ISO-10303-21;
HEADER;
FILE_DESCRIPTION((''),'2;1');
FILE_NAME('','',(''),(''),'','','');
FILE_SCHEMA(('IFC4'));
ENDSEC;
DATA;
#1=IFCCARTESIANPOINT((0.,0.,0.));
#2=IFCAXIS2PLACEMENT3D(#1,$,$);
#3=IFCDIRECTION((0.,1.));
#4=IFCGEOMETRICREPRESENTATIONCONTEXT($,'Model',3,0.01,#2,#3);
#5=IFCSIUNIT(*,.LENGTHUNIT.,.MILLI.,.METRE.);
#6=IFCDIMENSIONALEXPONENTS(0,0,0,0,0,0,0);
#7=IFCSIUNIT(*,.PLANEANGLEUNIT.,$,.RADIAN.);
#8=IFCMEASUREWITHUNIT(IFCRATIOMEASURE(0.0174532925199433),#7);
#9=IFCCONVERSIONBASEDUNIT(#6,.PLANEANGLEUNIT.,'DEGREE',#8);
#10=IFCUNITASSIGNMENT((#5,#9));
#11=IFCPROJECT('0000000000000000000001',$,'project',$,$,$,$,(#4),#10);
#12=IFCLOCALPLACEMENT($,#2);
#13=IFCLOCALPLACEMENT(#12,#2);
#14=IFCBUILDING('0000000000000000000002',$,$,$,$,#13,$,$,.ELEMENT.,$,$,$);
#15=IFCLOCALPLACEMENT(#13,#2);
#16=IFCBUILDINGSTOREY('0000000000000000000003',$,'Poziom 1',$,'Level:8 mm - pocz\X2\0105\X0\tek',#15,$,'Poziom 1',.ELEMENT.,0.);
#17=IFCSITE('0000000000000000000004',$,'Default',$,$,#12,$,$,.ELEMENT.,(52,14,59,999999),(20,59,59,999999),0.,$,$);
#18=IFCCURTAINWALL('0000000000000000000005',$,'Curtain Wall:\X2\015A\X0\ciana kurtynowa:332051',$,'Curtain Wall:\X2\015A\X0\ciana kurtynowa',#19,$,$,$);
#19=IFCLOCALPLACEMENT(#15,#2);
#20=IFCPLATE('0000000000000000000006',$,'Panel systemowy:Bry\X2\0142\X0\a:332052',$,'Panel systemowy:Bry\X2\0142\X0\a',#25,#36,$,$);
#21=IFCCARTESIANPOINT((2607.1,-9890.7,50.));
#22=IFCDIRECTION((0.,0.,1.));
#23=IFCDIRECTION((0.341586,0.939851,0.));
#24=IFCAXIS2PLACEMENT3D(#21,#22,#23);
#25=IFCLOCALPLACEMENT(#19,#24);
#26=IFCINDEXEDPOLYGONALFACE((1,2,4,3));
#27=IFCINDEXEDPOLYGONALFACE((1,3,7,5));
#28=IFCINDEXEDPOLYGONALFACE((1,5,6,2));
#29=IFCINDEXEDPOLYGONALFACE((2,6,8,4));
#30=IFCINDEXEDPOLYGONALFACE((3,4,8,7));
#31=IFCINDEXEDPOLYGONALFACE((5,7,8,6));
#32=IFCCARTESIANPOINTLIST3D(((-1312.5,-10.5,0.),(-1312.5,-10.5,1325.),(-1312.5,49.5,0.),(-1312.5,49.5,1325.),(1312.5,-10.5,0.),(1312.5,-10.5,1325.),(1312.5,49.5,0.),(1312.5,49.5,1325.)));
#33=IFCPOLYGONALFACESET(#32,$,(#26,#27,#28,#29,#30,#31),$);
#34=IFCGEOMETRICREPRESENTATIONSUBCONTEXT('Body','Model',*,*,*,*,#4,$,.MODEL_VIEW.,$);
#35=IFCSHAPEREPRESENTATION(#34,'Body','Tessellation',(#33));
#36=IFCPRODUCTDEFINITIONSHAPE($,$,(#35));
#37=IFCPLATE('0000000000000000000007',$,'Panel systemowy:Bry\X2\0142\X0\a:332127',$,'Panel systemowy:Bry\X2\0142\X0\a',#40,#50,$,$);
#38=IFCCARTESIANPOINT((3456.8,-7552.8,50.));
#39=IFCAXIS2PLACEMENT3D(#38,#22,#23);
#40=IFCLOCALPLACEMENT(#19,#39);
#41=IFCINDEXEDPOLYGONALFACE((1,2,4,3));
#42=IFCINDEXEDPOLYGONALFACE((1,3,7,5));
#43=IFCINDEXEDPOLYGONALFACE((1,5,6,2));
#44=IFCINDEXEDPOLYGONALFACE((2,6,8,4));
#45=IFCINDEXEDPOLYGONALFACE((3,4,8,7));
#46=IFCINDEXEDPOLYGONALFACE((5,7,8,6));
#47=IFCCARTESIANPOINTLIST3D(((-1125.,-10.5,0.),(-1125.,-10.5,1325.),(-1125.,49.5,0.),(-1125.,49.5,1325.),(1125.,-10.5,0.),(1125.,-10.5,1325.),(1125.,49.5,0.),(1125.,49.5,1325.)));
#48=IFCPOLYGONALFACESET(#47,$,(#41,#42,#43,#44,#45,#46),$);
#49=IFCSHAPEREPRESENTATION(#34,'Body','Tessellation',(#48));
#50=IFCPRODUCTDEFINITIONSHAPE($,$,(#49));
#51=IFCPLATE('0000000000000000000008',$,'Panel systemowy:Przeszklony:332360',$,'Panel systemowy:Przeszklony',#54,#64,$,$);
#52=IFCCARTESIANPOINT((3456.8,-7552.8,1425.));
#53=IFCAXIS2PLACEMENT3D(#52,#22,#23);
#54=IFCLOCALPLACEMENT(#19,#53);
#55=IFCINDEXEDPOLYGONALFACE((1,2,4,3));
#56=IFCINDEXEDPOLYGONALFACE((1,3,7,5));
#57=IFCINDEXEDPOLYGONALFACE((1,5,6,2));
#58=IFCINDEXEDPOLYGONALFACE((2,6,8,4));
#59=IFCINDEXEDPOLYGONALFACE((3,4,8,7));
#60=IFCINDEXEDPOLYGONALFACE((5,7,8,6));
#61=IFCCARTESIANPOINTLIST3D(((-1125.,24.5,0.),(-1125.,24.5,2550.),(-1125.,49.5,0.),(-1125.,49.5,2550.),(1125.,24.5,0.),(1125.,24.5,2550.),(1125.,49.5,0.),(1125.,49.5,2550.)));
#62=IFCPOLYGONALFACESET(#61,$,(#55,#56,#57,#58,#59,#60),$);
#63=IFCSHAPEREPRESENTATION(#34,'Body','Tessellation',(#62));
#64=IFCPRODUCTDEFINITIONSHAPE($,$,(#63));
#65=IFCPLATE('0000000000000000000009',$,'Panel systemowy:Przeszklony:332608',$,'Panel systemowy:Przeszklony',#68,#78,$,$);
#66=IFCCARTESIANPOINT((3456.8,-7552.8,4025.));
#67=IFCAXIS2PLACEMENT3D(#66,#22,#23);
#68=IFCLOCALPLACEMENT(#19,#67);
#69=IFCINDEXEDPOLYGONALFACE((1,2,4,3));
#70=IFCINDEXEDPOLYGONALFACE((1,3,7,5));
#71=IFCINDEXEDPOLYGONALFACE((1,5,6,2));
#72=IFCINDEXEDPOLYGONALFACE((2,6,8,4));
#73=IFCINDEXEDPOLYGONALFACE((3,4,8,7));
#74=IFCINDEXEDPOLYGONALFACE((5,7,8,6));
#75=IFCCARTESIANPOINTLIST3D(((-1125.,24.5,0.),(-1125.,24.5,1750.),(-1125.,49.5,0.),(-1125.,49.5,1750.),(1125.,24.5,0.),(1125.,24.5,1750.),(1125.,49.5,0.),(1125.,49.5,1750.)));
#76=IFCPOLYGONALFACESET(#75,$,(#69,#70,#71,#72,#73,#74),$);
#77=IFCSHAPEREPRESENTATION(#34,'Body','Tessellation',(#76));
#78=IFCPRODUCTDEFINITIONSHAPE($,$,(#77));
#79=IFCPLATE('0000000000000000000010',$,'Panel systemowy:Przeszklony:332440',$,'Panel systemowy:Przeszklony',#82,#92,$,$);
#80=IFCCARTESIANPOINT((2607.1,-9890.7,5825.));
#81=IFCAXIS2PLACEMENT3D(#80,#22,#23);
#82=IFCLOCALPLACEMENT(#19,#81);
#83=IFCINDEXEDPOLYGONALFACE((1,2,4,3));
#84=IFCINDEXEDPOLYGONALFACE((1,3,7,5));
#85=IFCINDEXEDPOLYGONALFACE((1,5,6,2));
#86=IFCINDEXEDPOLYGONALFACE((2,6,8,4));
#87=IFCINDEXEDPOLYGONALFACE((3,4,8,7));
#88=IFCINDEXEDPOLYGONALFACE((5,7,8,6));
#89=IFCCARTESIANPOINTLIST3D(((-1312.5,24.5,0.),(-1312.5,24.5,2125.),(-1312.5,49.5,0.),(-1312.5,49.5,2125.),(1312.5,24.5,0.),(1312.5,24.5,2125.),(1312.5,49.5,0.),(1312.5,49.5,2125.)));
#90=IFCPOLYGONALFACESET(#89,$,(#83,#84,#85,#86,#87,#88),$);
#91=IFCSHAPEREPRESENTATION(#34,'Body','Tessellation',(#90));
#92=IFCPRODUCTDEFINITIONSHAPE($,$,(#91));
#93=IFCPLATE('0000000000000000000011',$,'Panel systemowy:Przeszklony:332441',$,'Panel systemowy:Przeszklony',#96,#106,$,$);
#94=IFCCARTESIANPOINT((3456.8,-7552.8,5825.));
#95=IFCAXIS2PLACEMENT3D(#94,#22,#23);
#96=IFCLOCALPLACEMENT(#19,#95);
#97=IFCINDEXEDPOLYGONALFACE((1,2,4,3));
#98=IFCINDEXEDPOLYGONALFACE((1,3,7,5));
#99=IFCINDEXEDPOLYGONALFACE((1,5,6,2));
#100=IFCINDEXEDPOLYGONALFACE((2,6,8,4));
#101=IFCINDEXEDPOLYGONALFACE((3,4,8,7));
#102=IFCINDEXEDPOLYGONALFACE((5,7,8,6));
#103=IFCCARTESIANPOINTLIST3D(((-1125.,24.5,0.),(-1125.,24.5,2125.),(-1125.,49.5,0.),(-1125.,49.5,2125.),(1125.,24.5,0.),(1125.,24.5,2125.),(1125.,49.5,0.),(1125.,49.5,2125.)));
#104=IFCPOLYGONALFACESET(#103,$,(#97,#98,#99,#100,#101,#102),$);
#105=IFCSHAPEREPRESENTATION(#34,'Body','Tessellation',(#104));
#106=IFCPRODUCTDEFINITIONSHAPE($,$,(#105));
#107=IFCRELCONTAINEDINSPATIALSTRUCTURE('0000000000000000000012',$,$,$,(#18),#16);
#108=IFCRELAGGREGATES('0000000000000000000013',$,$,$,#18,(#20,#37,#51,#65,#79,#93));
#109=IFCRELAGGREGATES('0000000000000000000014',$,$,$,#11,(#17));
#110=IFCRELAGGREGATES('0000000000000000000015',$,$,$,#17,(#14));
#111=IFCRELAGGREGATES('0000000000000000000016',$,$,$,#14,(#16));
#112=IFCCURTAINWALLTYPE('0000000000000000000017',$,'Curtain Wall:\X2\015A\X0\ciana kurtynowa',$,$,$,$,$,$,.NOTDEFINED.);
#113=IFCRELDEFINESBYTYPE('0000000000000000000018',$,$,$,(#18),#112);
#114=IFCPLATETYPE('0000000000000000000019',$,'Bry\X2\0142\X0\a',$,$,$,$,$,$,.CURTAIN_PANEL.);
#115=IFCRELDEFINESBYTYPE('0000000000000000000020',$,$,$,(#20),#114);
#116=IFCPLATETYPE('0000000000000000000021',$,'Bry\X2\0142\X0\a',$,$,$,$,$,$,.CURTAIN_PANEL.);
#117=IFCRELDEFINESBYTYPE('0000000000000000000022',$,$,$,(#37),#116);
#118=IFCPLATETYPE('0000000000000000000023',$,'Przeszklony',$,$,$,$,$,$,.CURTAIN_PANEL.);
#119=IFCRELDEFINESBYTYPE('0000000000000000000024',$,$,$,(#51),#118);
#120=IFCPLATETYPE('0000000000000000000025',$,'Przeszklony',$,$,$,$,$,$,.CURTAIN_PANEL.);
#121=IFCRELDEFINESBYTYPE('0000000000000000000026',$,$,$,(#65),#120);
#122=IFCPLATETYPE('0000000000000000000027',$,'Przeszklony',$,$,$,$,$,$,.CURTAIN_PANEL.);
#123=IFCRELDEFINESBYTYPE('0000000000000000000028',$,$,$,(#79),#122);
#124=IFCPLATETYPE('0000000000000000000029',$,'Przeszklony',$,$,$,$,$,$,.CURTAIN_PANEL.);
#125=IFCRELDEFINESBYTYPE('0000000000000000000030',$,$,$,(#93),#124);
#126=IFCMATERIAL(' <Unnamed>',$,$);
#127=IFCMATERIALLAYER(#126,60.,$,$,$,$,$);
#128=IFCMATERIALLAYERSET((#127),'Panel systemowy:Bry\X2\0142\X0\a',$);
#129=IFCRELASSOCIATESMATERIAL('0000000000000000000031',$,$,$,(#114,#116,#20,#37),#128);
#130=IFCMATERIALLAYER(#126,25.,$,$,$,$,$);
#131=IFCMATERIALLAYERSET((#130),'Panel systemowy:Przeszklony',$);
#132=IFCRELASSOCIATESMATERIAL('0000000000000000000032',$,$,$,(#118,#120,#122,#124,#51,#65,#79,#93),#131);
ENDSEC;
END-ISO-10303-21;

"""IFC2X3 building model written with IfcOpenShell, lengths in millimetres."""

from ifc_helpers import new_model, entity, si_unit, converted_unit, direction, frame, frame_2d, origin, origin_2d_with_axis, place, context, subcontext, project, spatial, rectangle, extrude, source, transform, mapped, material, layer, layer_set, layer_usage, type_object, type_shapes, element, aggregate, save


model = new_model("IFC2X3")

# Units and contexts
model_context = context("Model", 3, precision=0.01, world=origin(), true_north=direction((0.0, 1.0)))
body_context = subcontext(model_context, "Body", "Model", "MODEL_VIEW")
ifc_project = project(units=[si_unit("LENGTHUNIT", "METRE", prefix="MILLI"), converted_unit("PLANEANGLEUNIT", "DEGREE", entity("IfcRatioMeasure", 0.0174532925199433), si_unit("PLANEANGLEUNIT", "RADIAN"), dimensions=[0, 0, 0, 0, 0, 0, 0])], contexts=[model_context])

# Site, building, storey
site_placement = place(None, origin())
site = spatial("IfcSite", under=ifc_project, at=site_placement, Name="Default", CompositionType="ELEMENT", RefLatitude=(52, 14, 59, 999999), RefLongitude=(20, 59, 59, 999999), RefElevation=0.0)
building_placement = place(site_placement, origin())
building = spatial("IfcBuilding", under=site, at=building_placement, CompositionType="ELEMENT")
storey_placement = place(building_placement, origin())
storey = spatial("IfcBuildingStorey", under=building, at=storey_placement, Name="Poziom 1", ObjectType="Level:8 mm - początek", LongName="Poziom 1", CompositionType="ELEMENT", Elevation=0.0)

# Curtain wall, plates
curtain_wall_type = type_object("IfcCurtainWallType", Name="Curtain Wall:Ściana kurtynowa", PredefinedType="NOTDEFINED")
curtain_wall_placement = place(storey_placement, origin())
curtain_wall = element("IfcCurtainWall", 1, at=curtain_wall_placement, inside=storey, type_object=curtain_wall_type, Name="Curtain Wall:Ściana kurtynowa:332051", ObjectType="Curtain Wall:Ściana kurtynowa")
ifc_material_1 = material(Name=" <Unnamed>")
ifc_layer_1 = layer(ifc_material_1, 60.0)
ifc_layer_set_1 = layer_set([ifc_layer_1], Name="Panel systemowy:Bryła")
ifc_layer_usage_1 = layer_usage(ifc_layer_set_1, "AXIS3", "POSITIVE", 0.1)
plate_type_1 = type_object("IfcPlateType", Name="Bryła", PredefinedType="CURTAIN_PANEL", material=ifc_layer_set_1)
shared_shape_1 = source(origin(), body_context, "Body", "SweptSolid", [
    extrude(rectangle(XDim=60.0, YDim=2625.0, at=frame_2d((0.0, 0.0), x_axis=(1.0, 0.0))), frame((0.0, 19.5, 0.0), z_axis=(0.0, 0.0, 1.0), x_axis=(0.0, 1.0, 0.0)), (0.0, 0.0, 1.0), 1325.0),
])
type_shapes(plate_type_1, [shared_shape_1])
plate_1_placement = place(curtain_wall_placement, frame((2607.1, -9890.7, 50.0), z_axis=(0.0, 0.0, 1.0), x_axis=(0.341586, 0.939851, 0.0)))
plate_1 = element("IfcPlate", 2, at=plate_1_placement, type_object=plate_type_1, material=ifc_layer_usage_1, Name="Panel systemowy:Bryła:332052", ObjectType="Panel systemowy:Bryła", context=body_context, shape_type="MappedRepresentation", body=[
    mapped(shared_shape_1, transform((0.0, 0.0, 0.0), scale=1.0)),
])
ifc_layer_usage_2 = layer_usage(ifc_layer_set_1, "AXIS3", "POSITIVE", 0.1)
plate_type_2 = type_object("IfcPlateType", Name="Bryła", PredefinedType="CURTAIN_PANEL", material=ifc_layer_set_1)
shared_shape_2 = source(origin(), body_context, "Body", "SweptSolid", [
    extrude(rectangle(XDim=60.0, YDim=2250.0, at=origin_2d_with_axis()), frame((0.0, 19.5, 0.0), z_axis=(0.0, 0.0, 1.0), x_axis=(0.0, 1.0, 0.0)), (0.0, 0.0, 1.0), 1325.0),
])
type_shapes(plate_type_2, [shared_shape_2])
plate_2_placement = place(curtain_wall_placement, frame((3456.8, -7552.8, 50.0), z_axis=(0.0, 0.0, 1.0), x_axis=(0.341586, 0.939851, 0.0)))
plate_2 = element("IfcPlate", 3, at=plate_2_placement, type_object=plate_type_2, material=ifc_layer_usage_2, Name="Panel systemowy:Bryła:332127", ObjectType="Panel systemowy:Bryła", context=body_context, shape_type="MappedRepresentation", body=[
    mapped(shared_shape_2, transform((0.0, 0.0, 0.0), scale=1.0)),
])
ifc_layer_2 = layer(ifc_material_1, 25.0)
ifc_layer_set_2 = layer_set([ifc_layer_2], Name="Panel systemowy:Przeszklony")
ifc_layer_usage_3 = layer_usage(ifc_layer_set_2, "AXIS3", "POSITIVE", 0.1)
plate_type_3 = type_object("IfcPlateType", Name="Przeszklony", PredefinedType="CURTAIN_PANEL", material=ifc_layer_set_2)
shared_shape_3 = source(origin(), body_context, "Body", "SweptSolid", [
    extrude(rectangle(XDim=25.0, YDim=2250.0, at=frame_2d((0.0, 0.0), x_axis=(1.0, 0.0))), frame((0.0, 37.0, 0.0), z_axis=(0.0, 0.0, 1.0), x_axis=(0.0, 1.0, 0.0)), (0.0, 0.0, 1.0), 2550.0),
])
type_shapes(plate_type_3, [shared_shape_3])
plate_3_placement = place(curtain_wall_placement, frame((3456.8, -7552.8, 1425.0), z_axis=(0.0, 0.0, 1.0), x_axis=(0.341586, 0.939851, 0.0)))
plate_3 = element("IfcPlate", 4, at=plate_3_placement, type_object=plate_type_3, material=ifc_layer_usage_3, Name="Panel systemowy:Przeszklony:332360", ObjectType="Panel systemowy:Przeszklony", context=body_context, shape_type="MappedRepresentation", body=[
    mapped(shared_shape_3, transform((0.0, 0.0, 0.0), scale=1.0)),
])
ifc_layer_usage_4 = layer_usage(ifc_layer_set_2, "AXIS3", "POSITIVE", 0.1)
plate_type_4 = type_object("IfcPlateType", Name="Przeszklony", PredefinedType="CURTAIN_PANEL", material=ifc_layer_set_2)
shared_shape_4 = source(origin(), body_context, "Body", "SweptSolid", [
    extrude(rectangle(XDim=25.0, YDim=2250.0, at=frame_2d((0.0, 0.0), x_axis=(1.0, 0.0))), frame((0.0, 37.0, 0.0), z_axis=(0.0, 0.0, 1.0), x_axis=(0.0, 1.0, 0.0)), (0.0, 0.0, 1.0), 1750.0),
])
type_shapes(plate_type_4, [shared_shape_4])
plate_4_placement = place(curtain_wall_placement, frame((3456.8, -7552.8, 4025.0), z_axis=(0.0, 0.0, 1.0), x_axis=(0.341586, 0.939851, 0.0)))
plate_4 = element("IfcPlate", 5, at=plate_4_placement, type_object=plate_type_4, material=ifc_layer_usage_4, Name="Panel systemowy:Przeszklony:332608", ObjectType="Panel systemowy:Przeszklony", context=body_context, shape_type="MappedRepresentation", body=[
    mapped(shared_shape_4, transform((0.0, 0.0, 0.0), scale=1.0)),
])
ifc_layer_usage_5 = layer_usage(ifc_layer_set_2, "AXIS3", "POSITIVE", 0.1)
plate_type_5 = type_object("IfcPlateType", Name="Przeszklony", PredefinedType="CURTAIN_PANEL", material=ifc_layer_set_2)
shared_shape_5 = source(origin(), body_context, "Body", "SweptSolid", [
    extrude(rectangle(XDim=25.0, YDim=2625.0, at=frame_2d((0.0, 0.0), x_axis=(1.0, 0.0))), frame((0.0, 37.0, 0.0), z_axis=(0.0, 0.0, 1.0), x_axis=(0.0, 1.0, 0.0)), (0.0, 0.0, 1.0), 2125.0),
])
type_shapes(plate_type_5, [shared_shape_5])
plate_5_placement = place(curtain_wall_placement, frame((2607.1, -9890.7, 5825.0), z_axis=(0.0, 0.0, 1.0), x_axis=(0.341586, 0.939851, 0.0)))
plate_5 = element("IfcPlate", 6, at=plate_5_placement, type_object=plate_type_5, material=ifc_layer_usage_5, Name="Panel systemowy:Przeszklony:332440", ObjectType="Panel systemowy:Przeszklony", context=body_context, shape_type="MappedRepresentation", body=[
    mapped(shared_shape_5, transform((0.0, 0.0, 0.0), scale=1.0)),
])
ifc_layer_usage_6 = layer_usage(ifc_layer_set_2, "AXIS3", "POSITIVE", 0.1)
plate_type_6 = type_object("IfcPlateType", Name="Przeszklony", PredefinedType="CURTAIN_PANEL", material=ifc_layer_set_2)
shared_shape_6 = source(origin(), body_context, "Body", "SweptSolid", [
    extrude(rectangle(XDim=25.0, YDim=2250.0, at=frame_2d((0.0, 0.0), x_axis=(1.0, 0.0))), frame((0.0, 37.0, 0.0), z_axis=(0.0, 0.0, 1.0), x_axis=(0.0, 1.0, 0.0)), (0.0, 0.0, 1.0), 2125.0),
])
type_shapes(plate_type_6, [shared_shape_6])
plate_6_placement = place(curtain_wall_placement, frame((3456.8, -7552.8, 5825.0), z_axis=(0.0, 0.0, 1.0), x_axis=(0.341586, 0.939851, 0.0)))
plate_6 = element("IfcPlate", 7, at=plate_6_placement, type_object=plate_type_6, material=ifc_layer_usage_6, Name="Panel systemowy:Przeszklony:332441", ObjectType="Panel systemowy:Przeszklony", context=body_context, shape_type="MappedRepresentation", body=[
    mapped(shared_shape_6, transform((0.0, 0.0, 0.0), scale=1.0)),
])
aggregate(curtain_wall, [plate_1, plate_2, plate_3, plate_4, plate_5, plate_6])

save(model, "model.ifc")
